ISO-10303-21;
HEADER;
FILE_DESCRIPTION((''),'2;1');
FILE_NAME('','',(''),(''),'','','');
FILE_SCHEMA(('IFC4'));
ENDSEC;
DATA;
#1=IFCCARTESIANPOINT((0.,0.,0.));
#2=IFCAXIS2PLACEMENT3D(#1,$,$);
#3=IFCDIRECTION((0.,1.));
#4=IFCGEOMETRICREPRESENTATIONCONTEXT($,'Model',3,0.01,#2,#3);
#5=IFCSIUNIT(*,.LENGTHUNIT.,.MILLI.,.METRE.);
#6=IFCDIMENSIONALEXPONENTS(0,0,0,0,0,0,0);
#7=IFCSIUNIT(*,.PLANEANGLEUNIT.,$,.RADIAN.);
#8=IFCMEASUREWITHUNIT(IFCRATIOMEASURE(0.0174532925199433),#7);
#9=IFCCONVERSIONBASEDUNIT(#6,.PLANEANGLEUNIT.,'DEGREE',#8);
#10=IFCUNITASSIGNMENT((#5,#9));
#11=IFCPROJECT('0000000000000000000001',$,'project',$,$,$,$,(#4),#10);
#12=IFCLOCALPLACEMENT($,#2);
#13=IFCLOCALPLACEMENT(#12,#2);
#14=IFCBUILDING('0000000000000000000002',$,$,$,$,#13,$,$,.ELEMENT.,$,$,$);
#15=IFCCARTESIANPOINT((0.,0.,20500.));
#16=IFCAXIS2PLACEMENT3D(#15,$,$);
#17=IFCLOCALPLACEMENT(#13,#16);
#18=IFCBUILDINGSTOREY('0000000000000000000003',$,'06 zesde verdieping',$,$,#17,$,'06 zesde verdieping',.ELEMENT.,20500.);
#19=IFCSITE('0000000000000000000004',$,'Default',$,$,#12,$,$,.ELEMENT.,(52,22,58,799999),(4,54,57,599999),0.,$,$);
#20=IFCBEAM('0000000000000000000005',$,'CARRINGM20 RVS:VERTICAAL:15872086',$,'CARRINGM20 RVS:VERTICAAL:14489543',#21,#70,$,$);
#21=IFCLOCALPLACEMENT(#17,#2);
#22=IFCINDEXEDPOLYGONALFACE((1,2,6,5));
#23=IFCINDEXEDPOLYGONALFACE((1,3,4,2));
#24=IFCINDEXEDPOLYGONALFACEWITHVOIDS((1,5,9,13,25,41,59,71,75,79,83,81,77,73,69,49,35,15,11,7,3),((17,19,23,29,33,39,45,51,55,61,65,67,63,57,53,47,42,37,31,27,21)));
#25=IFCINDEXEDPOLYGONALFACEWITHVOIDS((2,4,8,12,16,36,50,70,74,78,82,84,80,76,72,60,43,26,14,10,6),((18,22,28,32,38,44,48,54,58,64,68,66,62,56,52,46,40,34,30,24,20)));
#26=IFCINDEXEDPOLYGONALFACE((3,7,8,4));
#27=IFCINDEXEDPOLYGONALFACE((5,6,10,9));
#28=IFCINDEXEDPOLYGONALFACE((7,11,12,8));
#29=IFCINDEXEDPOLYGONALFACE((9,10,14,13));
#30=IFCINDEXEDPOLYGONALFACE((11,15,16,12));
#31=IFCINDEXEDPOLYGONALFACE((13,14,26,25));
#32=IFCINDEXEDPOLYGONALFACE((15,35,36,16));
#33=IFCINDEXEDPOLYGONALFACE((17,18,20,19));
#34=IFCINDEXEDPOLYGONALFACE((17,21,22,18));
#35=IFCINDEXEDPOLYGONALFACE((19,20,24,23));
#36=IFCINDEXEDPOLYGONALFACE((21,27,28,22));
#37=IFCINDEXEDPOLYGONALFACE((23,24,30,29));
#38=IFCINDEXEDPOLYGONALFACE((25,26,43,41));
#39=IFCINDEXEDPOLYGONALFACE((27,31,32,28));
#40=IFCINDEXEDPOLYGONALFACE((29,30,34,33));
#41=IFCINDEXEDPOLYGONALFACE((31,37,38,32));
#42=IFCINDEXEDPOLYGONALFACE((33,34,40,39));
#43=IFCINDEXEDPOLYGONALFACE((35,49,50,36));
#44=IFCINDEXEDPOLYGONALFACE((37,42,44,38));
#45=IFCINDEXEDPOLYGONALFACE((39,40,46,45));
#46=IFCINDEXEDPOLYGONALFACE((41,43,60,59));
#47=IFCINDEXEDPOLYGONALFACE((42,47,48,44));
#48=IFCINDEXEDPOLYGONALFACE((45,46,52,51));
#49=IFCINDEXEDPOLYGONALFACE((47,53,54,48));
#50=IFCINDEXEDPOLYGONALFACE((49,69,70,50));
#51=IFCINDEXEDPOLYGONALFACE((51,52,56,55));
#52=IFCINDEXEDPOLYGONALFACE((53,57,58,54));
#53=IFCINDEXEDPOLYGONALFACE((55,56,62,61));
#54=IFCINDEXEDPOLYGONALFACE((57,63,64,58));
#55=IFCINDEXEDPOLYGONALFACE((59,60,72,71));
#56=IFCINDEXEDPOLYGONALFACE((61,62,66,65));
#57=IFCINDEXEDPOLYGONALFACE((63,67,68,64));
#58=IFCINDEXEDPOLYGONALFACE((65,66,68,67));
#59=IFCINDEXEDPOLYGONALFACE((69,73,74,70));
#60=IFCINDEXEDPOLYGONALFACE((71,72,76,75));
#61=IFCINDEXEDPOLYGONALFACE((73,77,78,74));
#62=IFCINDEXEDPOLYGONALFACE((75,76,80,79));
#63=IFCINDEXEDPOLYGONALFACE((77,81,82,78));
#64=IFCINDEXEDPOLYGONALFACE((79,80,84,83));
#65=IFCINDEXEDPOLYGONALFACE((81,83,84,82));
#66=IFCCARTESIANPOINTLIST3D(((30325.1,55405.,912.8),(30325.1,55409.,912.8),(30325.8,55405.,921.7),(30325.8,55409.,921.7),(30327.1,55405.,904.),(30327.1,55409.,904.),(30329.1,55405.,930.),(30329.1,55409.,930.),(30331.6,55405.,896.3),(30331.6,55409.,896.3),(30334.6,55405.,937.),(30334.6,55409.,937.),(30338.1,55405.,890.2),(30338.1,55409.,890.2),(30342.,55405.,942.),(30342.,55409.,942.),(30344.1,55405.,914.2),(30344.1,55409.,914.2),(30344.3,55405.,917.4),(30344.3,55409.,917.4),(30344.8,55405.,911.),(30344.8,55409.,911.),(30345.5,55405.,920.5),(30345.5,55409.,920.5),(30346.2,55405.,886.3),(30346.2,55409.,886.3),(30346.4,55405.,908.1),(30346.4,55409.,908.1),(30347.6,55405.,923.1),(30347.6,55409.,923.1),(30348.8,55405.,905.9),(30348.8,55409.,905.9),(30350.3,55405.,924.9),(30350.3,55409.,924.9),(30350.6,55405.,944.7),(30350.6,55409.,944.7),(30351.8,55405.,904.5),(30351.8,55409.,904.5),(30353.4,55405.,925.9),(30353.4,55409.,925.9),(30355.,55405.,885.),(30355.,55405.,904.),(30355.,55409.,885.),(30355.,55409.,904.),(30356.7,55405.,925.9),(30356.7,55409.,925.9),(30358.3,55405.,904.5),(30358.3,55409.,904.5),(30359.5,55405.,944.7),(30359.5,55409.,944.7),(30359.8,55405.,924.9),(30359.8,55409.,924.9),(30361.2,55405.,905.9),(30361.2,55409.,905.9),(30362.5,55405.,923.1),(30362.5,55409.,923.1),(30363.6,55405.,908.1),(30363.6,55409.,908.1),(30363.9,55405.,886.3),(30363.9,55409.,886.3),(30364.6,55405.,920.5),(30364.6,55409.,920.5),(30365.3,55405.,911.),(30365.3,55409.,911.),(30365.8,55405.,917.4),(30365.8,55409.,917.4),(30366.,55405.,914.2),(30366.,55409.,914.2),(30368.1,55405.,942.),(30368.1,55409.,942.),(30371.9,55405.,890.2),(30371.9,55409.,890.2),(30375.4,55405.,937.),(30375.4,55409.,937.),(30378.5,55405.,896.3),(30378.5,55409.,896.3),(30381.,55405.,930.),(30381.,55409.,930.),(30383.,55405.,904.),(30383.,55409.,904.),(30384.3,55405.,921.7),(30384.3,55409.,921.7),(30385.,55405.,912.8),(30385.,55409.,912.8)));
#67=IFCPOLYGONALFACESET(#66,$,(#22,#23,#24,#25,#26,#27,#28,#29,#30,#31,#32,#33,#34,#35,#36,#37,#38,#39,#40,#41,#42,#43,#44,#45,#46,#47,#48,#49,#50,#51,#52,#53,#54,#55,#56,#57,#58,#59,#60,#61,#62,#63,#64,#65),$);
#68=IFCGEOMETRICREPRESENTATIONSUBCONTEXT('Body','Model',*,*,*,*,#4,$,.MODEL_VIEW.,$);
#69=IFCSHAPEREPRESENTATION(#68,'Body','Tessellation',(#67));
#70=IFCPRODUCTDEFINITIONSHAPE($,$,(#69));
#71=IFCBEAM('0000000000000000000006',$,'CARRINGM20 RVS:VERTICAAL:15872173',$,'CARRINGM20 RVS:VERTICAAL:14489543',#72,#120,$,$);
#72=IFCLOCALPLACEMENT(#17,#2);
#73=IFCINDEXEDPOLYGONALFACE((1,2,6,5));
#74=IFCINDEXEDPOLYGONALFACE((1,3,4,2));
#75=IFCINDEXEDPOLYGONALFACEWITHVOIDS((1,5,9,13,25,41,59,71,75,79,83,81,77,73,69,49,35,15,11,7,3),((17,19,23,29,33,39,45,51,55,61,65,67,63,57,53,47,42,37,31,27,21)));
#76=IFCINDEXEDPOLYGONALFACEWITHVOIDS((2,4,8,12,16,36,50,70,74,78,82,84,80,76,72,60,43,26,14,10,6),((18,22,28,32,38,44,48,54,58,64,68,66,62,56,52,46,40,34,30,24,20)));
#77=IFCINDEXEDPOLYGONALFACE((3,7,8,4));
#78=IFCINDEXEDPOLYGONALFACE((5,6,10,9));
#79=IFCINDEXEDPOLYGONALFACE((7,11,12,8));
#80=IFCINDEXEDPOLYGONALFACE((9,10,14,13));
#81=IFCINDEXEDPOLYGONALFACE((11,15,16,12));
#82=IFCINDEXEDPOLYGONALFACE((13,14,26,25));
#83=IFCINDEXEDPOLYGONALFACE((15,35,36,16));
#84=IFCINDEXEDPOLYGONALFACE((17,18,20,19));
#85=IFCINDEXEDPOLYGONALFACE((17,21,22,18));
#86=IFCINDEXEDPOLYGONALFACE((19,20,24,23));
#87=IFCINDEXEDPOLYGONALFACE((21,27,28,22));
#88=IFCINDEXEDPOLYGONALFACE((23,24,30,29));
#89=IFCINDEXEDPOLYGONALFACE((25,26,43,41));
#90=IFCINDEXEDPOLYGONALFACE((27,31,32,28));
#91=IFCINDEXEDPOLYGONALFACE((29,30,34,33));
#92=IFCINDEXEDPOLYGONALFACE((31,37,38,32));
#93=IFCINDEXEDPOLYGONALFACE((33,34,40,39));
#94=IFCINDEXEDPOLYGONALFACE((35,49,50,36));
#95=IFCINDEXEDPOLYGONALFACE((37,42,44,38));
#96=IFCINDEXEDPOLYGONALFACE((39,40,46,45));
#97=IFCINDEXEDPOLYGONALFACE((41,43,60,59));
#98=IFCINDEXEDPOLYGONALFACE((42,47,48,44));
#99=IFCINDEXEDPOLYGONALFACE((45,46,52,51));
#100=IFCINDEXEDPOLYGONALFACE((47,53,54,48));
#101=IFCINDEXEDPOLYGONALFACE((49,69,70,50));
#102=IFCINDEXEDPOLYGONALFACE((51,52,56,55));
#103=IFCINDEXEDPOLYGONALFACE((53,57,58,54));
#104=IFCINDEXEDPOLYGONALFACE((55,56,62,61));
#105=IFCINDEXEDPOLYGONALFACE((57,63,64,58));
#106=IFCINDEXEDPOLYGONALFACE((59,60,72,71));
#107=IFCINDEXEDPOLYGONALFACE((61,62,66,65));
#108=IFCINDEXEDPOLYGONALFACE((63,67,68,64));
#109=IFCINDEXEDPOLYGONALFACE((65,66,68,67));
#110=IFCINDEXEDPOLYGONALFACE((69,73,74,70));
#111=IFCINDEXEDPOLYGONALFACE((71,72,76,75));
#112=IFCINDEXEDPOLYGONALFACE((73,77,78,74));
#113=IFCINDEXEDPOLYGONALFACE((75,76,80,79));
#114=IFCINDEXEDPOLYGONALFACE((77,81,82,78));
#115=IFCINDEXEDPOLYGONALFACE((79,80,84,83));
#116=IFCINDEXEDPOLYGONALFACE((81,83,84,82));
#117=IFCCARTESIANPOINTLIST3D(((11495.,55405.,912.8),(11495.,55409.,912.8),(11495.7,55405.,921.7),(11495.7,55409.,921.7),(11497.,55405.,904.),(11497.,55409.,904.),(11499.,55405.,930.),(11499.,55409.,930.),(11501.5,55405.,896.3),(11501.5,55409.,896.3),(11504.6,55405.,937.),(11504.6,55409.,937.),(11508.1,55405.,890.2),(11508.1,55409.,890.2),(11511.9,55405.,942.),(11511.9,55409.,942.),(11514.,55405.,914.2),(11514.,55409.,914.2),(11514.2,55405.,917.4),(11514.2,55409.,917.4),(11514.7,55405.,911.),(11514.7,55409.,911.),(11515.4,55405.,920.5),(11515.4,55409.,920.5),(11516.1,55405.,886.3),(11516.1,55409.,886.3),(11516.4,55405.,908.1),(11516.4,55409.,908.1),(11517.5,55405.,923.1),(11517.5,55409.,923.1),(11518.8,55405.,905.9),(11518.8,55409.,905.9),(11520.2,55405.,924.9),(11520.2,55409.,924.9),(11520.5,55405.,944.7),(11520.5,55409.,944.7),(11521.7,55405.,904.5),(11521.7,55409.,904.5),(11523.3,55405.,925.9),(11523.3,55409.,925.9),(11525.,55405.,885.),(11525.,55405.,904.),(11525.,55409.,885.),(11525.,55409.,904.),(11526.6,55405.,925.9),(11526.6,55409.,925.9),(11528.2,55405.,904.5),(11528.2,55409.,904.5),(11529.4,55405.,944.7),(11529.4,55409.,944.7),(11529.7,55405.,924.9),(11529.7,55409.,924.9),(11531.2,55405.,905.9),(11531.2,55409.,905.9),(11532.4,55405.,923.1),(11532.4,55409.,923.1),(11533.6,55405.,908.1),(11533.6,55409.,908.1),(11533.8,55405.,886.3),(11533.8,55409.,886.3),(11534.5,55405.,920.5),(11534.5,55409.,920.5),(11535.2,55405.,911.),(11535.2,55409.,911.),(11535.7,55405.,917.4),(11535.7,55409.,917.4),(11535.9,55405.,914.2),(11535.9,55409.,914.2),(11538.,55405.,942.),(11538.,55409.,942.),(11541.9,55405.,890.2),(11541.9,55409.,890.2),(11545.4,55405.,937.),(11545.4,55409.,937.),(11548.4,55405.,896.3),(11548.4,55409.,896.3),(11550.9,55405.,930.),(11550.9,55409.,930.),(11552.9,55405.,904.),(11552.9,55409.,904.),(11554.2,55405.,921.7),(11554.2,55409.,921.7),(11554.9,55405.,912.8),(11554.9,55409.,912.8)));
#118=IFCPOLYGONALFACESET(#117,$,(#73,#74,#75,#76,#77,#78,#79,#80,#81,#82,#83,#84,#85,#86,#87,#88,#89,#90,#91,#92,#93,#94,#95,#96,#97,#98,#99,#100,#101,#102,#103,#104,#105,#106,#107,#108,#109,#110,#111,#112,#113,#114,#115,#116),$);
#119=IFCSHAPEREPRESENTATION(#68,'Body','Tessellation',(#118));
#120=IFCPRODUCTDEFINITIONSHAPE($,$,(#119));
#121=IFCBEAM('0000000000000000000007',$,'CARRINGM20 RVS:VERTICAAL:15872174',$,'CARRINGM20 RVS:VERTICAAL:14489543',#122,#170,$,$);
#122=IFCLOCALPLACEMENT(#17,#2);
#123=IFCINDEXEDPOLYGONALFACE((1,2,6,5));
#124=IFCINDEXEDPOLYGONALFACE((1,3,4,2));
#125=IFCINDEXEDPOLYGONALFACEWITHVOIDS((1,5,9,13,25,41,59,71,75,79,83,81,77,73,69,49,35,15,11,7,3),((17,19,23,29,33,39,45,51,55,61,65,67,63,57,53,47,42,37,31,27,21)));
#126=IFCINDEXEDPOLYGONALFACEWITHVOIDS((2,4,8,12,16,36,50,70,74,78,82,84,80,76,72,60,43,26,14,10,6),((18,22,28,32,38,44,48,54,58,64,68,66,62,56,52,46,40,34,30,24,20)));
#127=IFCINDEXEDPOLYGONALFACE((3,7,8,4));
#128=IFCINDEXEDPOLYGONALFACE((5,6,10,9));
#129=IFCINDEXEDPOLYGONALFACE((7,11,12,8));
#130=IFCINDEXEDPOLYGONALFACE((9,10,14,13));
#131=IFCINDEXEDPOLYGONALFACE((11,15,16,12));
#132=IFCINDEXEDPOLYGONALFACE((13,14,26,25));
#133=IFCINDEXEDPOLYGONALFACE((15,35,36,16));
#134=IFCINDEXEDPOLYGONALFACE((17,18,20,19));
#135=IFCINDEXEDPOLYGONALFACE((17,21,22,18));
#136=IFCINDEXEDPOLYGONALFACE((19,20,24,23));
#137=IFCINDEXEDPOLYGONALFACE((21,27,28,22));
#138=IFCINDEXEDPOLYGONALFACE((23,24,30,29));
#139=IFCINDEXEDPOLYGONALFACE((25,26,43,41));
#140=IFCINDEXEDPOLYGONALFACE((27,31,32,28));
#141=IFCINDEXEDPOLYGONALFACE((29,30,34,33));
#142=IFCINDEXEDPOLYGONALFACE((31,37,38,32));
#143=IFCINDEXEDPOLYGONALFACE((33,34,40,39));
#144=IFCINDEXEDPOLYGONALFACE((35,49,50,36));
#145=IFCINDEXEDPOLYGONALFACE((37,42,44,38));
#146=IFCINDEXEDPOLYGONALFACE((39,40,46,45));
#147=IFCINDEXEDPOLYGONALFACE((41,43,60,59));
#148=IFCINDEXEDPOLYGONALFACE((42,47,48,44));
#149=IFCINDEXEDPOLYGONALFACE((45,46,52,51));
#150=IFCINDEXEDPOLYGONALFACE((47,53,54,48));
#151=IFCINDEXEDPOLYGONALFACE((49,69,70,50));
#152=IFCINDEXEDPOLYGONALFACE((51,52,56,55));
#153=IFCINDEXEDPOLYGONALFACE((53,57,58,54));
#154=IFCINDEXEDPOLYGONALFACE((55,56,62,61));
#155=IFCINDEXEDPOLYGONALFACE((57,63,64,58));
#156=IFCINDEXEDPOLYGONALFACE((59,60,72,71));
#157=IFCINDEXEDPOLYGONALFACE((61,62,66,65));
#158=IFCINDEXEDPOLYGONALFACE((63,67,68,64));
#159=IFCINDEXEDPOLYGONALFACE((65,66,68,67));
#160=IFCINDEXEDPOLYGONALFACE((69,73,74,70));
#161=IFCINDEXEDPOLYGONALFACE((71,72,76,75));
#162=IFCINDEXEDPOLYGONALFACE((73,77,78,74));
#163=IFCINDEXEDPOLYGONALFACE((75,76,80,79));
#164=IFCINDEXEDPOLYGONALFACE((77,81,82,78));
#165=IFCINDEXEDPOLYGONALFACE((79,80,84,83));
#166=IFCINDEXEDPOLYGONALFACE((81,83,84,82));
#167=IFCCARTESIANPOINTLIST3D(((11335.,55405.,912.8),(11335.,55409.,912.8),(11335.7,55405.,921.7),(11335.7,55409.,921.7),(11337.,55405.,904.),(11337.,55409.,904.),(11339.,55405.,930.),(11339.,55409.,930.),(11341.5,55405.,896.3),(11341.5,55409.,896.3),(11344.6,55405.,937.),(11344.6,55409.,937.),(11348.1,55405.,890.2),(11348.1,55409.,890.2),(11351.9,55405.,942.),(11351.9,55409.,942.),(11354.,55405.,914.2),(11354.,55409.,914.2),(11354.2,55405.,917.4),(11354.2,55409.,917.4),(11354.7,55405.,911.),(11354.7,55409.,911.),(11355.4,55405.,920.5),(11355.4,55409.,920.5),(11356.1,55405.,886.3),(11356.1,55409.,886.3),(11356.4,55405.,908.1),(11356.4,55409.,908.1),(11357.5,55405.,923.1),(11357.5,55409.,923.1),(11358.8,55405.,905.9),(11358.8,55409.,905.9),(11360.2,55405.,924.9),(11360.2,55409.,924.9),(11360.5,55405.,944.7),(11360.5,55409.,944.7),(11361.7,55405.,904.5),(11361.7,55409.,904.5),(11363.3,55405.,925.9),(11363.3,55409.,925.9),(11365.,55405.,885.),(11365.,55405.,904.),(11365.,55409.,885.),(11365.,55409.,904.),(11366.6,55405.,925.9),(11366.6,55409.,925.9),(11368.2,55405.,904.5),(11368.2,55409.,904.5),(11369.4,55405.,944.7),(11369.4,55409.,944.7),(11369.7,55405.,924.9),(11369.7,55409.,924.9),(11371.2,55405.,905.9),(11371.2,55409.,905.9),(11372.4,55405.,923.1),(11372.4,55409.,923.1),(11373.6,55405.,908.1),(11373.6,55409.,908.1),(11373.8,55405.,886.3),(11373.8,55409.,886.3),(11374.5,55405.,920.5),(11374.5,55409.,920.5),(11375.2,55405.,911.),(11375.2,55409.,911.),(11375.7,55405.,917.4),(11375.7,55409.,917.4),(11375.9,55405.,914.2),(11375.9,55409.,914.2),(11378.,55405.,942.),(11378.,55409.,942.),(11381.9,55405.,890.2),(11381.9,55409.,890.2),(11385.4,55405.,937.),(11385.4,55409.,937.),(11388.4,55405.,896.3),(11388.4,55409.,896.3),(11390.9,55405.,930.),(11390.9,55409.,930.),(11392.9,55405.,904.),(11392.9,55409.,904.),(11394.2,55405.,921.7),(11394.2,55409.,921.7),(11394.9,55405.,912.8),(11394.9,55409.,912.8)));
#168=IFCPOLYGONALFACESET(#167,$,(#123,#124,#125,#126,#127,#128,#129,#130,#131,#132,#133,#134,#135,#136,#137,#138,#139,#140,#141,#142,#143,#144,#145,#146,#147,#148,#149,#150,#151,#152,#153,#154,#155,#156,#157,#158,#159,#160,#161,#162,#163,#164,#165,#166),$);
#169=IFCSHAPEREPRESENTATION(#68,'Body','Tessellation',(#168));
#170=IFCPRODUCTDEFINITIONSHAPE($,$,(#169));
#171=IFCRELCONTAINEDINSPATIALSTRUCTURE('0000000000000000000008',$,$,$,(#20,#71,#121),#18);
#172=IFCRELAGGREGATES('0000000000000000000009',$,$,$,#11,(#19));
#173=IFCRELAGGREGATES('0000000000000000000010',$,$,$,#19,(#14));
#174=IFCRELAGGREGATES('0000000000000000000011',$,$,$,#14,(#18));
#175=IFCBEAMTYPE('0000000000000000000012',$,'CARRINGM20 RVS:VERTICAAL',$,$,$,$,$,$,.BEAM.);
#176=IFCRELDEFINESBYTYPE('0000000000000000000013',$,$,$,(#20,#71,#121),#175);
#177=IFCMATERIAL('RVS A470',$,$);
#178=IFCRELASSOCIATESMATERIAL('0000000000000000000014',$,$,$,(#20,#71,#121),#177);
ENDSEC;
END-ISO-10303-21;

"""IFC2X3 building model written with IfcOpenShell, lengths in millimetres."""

from ifc_helpers import new_model, entity, si_unit, converted_unit, direction, frame, origin, origin_2d_with_axis, place, context, subcontext, project, spatial, hollow_circle, extrude, material, type_object, element, save


model = new_model("IFC2X3")

# Units and contexts
model_context = context("Model", 3, precision=0.01, world=origin(), true_north=direction((0.0, 1.0)))
body_context = subcontext(model_context, "Body", "Model", "MODEL_VIEW")
ifc_project = project(units=[si_unit("LENGTHUNIT", "METRE", prefix="MILLI"), converted_unit("PLANEANGLEUNIT", "DEGREE", entity("IfcRatioMeasure", 0.0174532925199433), si_unit("PLANEANGLEUNIT", "RADIAN"), dimensions=[0, 0, 0, 0, 0, 0, 0])], contexts=[model_context])

# Site, building, storey
site_placement = place(None, origin())
site = spatial("IfcSite", under=ifc_project, at=site_placement, Name="Default", CompositionType="ELEMENT", RefLatitude=(52, 22, 58, 799999), RefLongitude=(4, 54, 57, 599999), RefElevation=0.0)
building_placement = place(site_placement, origin())
building = spatial("IfcBuilding", under=site, at=building_placement, CompositionType="ELEMENT")
storey_placement = place(building_placement, frame((0.0, 0.0, 20500.0)))
storey = spatial("IfcBuildingStorey", under=building, at=storey_placement, Name="06 zesde verdieping", LongName="06 zesde verdieping", CompositionType="ELEMENT", Elevation=20500.0)

# Beams
ifc_material_1 = material(Name="RVS A470")
beam_type_1 = type_object("IfcBeamType", Name="CARRINGM20 RVS:VERTICAAL", PredefinedType="BEAM")
beam_1_placement = place(storey_placement, origin())
element("IfcBeam", 1, at=beam_1_placement, inside=storey, type_object=beam_type_1, material=ifc_material_1, Name="CARRINGM20 RVS:VERTICAAL:15872086", ObjectType="CARRINGM20 RVS:VERTICAAL:14489543", context=body_context, shape_type="SweptSolid", body=[
    extrude(hollow_circle(Radius=30.0, WallThickness=19.0, at=origin_2d_with_axis()), frame((30355.0, 55405.0, 915.0), z_axis=(0.0, 1.0, 0.0), x_axis=(0.0, 0.0, -1.0)), (0.0, 0.0, 1.0), 4.0),
])
beam_2_placement = place(storey_placement, origin())
element("IfcBeam", 2, at=beam_2_placement, inside=storey, type_object=beam_type_1, material=ifc_material_1, Name="CARRINGM20 RVS:VERTICAAL:15872173", ObjectType="CARRINGM20 RVS:VERTICAAL:14489543", context=body_context, shape_type="SweptSolid", body=[
    extrude(hollow_circle(Radius=30.0, WallThickness=19.0, at=origin_2d_with_axis()), frame((11525.0, 55405.0, 915.0), z_axis=(0.0, 1.0, 0.0), x_axis=(0.0, 0.0, -1.0)), (0.0, 0.0, 1.0), 4.0),
])
beam_3_placement = place(storey_placement, origin())
element("IfcBeam", 3, at=beam_3_placement, inside=storey, type_object=beam_type_1, material=ifc_material_1, Name="CARRINGM20 RVS:VERTICAAL:15872174", ObjectType="CARRINGM20 RVS:VERTICAAL:14489543", context=body_context, shape_type="SweptSolid", body=[
    extrude(hollow_circle(Radius=30.0, WallThickness=19.0, at=origin_2d_with_axis()), frame((11365.0, 55405.0, 915.0), z_axis=(0.0, 1.0, 0.0), x_axis=(0.0, 0.0, -1.0)), (0.0, 0.0, 1.0), 4.0),
])

save(model, "model.ifc")
